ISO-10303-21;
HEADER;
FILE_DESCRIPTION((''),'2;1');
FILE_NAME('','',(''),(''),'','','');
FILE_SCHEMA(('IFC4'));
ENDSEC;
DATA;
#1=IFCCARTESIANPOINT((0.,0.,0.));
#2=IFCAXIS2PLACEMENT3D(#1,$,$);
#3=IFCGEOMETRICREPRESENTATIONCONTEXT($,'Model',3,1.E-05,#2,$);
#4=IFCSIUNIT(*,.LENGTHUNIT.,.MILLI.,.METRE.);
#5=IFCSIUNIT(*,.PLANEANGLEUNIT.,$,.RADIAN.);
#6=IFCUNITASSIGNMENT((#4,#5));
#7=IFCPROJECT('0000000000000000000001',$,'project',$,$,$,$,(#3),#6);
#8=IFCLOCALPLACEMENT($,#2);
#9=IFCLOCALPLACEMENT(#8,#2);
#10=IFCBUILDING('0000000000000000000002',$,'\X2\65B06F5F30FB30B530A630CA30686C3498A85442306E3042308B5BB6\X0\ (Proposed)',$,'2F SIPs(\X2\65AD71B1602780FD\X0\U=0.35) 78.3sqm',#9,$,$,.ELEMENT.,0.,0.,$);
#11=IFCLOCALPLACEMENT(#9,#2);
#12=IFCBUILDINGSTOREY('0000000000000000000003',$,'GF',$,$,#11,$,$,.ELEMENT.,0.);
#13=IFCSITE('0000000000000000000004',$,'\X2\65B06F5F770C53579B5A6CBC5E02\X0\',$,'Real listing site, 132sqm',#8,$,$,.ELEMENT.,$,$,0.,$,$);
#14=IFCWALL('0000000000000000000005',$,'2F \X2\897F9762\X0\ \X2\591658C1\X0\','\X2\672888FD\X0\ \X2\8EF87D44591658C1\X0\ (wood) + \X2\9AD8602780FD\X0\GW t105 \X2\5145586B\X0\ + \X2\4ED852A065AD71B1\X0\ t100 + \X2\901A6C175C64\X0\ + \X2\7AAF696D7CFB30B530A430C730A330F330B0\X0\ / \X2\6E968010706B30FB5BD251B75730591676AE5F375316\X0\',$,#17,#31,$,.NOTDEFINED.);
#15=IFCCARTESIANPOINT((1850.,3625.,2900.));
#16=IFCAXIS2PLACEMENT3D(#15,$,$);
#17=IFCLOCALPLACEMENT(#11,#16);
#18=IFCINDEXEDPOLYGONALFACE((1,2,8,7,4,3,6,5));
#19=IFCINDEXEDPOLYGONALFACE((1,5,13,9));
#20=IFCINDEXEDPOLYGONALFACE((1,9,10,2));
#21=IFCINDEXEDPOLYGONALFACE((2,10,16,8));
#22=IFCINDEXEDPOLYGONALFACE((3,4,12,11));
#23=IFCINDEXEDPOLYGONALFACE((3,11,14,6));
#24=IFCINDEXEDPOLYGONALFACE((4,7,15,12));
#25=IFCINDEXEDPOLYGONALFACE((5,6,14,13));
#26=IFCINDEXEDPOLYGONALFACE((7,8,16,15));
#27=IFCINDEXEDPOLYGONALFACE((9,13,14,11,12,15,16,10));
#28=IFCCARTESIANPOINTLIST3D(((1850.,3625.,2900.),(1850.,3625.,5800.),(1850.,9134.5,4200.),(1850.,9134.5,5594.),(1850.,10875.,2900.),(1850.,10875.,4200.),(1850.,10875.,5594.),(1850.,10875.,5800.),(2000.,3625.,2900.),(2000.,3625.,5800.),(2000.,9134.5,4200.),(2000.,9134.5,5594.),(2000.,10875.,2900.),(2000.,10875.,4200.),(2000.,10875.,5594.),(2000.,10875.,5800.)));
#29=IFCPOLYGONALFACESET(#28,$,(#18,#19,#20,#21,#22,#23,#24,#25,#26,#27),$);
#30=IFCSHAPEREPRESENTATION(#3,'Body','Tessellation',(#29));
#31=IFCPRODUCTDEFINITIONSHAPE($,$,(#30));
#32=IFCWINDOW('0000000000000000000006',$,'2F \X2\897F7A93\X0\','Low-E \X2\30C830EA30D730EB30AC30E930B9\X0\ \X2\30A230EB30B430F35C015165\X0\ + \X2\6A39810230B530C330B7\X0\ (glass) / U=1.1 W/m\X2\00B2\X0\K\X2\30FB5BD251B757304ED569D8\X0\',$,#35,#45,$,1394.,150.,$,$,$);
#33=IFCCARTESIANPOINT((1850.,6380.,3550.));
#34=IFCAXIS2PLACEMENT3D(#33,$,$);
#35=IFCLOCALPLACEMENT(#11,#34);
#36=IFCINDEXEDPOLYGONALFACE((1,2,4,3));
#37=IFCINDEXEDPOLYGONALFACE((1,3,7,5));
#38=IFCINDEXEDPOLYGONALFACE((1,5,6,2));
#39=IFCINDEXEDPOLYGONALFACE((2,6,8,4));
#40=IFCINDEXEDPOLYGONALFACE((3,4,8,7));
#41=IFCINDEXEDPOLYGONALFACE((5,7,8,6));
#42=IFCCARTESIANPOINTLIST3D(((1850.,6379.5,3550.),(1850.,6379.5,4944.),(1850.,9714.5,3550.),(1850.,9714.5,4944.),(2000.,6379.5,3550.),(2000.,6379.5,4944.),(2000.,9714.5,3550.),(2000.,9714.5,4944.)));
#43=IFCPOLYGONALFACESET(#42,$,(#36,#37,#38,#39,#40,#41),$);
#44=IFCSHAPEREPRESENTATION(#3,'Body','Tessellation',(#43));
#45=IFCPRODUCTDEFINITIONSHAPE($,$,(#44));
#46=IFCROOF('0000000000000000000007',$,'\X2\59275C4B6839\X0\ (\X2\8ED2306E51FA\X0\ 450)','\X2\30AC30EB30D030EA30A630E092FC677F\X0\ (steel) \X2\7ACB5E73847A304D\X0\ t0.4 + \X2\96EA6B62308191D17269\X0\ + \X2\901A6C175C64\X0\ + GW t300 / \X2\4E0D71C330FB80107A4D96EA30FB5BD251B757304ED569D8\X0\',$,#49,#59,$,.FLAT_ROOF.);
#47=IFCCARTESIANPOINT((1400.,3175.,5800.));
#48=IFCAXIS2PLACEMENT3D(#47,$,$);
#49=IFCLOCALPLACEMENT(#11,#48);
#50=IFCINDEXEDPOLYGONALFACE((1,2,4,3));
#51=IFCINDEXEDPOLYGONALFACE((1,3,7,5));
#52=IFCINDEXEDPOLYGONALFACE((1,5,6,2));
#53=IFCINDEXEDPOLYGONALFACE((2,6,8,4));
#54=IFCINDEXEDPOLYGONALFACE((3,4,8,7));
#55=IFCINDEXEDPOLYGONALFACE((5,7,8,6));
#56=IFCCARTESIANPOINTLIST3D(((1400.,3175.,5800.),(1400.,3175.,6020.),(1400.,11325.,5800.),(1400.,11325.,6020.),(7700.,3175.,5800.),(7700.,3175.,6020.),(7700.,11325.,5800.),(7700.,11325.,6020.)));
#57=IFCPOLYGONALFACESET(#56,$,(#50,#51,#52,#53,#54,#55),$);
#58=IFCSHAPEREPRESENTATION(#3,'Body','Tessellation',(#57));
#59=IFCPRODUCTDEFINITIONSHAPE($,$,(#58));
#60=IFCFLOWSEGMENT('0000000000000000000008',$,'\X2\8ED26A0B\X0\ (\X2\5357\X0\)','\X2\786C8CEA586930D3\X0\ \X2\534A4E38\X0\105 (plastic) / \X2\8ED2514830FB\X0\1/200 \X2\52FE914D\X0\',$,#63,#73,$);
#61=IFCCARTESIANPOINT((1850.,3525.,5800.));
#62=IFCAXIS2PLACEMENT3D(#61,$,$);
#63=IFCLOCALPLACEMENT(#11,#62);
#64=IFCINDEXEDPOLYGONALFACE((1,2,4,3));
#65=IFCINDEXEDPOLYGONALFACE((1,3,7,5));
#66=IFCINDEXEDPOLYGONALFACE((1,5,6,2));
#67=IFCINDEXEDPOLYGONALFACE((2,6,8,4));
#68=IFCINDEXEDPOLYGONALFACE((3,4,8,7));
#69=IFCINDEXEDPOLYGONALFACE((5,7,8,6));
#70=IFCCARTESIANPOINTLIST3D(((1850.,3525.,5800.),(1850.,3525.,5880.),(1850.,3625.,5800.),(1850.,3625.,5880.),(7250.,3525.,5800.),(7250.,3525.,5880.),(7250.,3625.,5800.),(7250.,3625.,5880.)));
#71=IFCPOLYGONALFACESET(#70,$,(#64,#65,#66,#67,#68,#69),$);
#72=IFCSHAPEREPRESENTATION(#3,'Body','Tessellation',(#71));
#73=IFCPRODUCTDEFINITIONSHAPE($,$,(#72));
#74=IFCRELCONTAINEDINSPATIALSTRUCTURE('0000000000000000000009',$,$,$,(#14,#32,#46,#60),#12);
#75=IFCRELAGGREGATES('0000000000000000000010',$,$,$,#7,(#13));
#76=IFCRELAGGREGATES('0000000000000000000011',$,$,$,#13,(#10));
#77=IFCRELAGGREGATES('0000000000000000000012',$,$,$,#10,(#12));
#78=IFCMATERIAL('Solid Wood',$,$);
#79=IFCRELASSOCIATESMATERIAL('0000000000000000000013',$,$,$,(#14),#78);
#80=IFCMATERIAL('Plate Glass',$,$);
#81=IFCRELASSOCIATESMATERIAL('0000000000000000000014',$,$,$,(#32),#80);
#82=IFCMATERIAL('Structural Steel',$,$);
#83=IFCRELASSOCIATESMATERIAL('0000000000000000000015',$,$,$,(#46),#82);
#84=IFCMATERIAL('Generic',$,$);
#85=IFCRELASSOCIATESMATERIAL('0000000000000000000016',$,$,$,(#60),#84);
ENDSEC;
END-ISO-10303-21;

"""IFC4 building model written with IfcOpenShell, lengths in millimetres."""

from ifc_helpers import new_model, si_unit, frame, frame_2d, origin, place, context, project, spatial, rectangle, extrude, material, element, fill, save


model = new_model("IFC4")

# Units and contexts
model_context = context("Model", 3, precision=1e-05, world=origin())
ifc_project = project(units=[si_unit("LENGTHUNIT", "METRE", prefix="MILLI"), si_unit("PLANEANGLEUNIT", "RADIAN")], contexts=[model_context])

# Site, building, storey
site_placement = place(None, origin())
site = spatial("IfcSite", under=ifc_project, at=site_placement, Name="新潟県南魚沼市", ObjectType="Real listing site, 132sqm", CompositionType="ELEMENT", RefElevation=0.0)
building_placement = place(site_placement, origin())
building = spatial("IfcBuilding", under=site, at=building_placement, Name="新潟・サウナと水風呂のある家 (Proposed)", ObjectType="2F SIPs(断熱性能U=0.35) 78.3sqm", CompositionType="ELEMENT", ElevationOfRefHeight=0.0, ElevationOfTerrain=0.0)
storey_placement = place(building_placement, origin())
storey = spatial("IfcBuildingStorey", under=building, at=storey_placement, Name="GF", CompositionType="ELEMENT", Elevation=0.0)

# Shared definitions
ifc_material_1 = material(Name="Solid Wood")

# Shared definitions
ifc_material_2 = material(Name="Plate Glass")

# Wall, opening, window
wall_1_placement = place(storey_placement, frame((1850.0, 3625.0, 2900.0)))
wall_1 = element("IfcWall", 1, at=wall_1_placement, inside=storey, material=ifc_material_1, Name="2F 西面 外壁", Description="木製 軸組外壁 (wood) + 高性能GW t105 充填 + 付加断熱 t100 + 通気層 + 窯業系サイディング / 準耐火・寒冷地外皮強化", PredefinedType="NOTDEFINED", context=model_context, shape_type="SweptSolid", body=[
    extrude(rectangle(XDim=150.0, YDim=7250.0, at=frame_2d((75.0, 3625.0))), frame((1850.0, 3625.0, 2900.0)), (0.0, 0.0, 1.0), 2900.0),
])
opening_1_placement = place(storey_placement, frame((1850.0, 6380.0, 3550.0)))
opening_1 = element("IfcOpeningElement", 2, at=opening_1_placement, cuts=wall_1, PredefinedType="NOTDEFINED", context=model_context, shape_type="SweptSolid", body=[
    extrude(rectangle(XDim=150.0, YDim=3335.0, at=frame_2d((75.0, 1667.0))), frame((1850.0, 6380.0, 3550.0)), (0.0, 0.0, 1.0), 1394.0),
])
window_1_placement = place(storey_placement, frame((1850.0, 6380.0, 3550.0)))
window_1 = element("IfcWindow", 3, at=window_1_placement, inside=storey, material=ifc_material_2, Name="2F 西窓", Description="Low-E トリプルガラス アルゴン封入 + 樹脂サッシ (glass) / U=1.1 W/m²K・寒冷地仕様", OverallHeight=1394.0, OverallWidth=150.0, context=model_context, shape_type="SweptSolid", body=[
    extrude(rectangle(XDim=150.0, YDim=3335.0, at=frame_2d((75.0, 1667.0))), frame((1850.0, 6380.0, 3550.0)), (0.0, 0.0, 1.0), 1394.0),
])
fill(opening_1, window_1)

# Roof
ifc_material_3 = material(Name="Structural Steel")
roof_placement = place(storey_placement, frame((1400.0, 3175.0, 5800.0)))
element("IfcRoof", 4, at=roof_placement, inside=storey, material=ifc_material_3, Name="大屋根 (軒の出 450)", Description="ガルバリウム鋼板 (steel) 立平葺き t0.4 + 雪止め金物 + 通気層 + GW t300 / 不燃・耐積雪・寒冷地仕様", PredefinedType="FLAT_ROOF", context=model_context, shape_type="SweptSolid", body=[
    extrude(rectangle(XDim=6300.0, YDim=8150.0, at=frame_2d((3150.0, 4075.0))), frame((1400.0, 3175.0, 5800.0)), (0.0, 0.0, 1.0), 220.0),
])

# Flow segment
ifc_material_4 = material(Name="Generic")
flow_segment_placement = place(storey_placement, frame((1850.0, 3525.0, 5800.0)))
element("IfcFlowSegment", 5, at=flow_segment_placement, inside=storey, material=ifc_material_4, Name="軒樋 (南)", Description="硬質塩ビ 半丸105 (plastic) / 軒先・1/200 勾配", context=model_context, shape_type="SweptSolid", body=[
    extrude(rectangle(XDim=5400.0, YDim=100.0, at=frame_2d((2700.0, 50.0))), frame((1850.0, 3525.0, 5800.0)), (0.0, 0.0, 1.0), 80.0),
])

save(model, "model.ifc")
